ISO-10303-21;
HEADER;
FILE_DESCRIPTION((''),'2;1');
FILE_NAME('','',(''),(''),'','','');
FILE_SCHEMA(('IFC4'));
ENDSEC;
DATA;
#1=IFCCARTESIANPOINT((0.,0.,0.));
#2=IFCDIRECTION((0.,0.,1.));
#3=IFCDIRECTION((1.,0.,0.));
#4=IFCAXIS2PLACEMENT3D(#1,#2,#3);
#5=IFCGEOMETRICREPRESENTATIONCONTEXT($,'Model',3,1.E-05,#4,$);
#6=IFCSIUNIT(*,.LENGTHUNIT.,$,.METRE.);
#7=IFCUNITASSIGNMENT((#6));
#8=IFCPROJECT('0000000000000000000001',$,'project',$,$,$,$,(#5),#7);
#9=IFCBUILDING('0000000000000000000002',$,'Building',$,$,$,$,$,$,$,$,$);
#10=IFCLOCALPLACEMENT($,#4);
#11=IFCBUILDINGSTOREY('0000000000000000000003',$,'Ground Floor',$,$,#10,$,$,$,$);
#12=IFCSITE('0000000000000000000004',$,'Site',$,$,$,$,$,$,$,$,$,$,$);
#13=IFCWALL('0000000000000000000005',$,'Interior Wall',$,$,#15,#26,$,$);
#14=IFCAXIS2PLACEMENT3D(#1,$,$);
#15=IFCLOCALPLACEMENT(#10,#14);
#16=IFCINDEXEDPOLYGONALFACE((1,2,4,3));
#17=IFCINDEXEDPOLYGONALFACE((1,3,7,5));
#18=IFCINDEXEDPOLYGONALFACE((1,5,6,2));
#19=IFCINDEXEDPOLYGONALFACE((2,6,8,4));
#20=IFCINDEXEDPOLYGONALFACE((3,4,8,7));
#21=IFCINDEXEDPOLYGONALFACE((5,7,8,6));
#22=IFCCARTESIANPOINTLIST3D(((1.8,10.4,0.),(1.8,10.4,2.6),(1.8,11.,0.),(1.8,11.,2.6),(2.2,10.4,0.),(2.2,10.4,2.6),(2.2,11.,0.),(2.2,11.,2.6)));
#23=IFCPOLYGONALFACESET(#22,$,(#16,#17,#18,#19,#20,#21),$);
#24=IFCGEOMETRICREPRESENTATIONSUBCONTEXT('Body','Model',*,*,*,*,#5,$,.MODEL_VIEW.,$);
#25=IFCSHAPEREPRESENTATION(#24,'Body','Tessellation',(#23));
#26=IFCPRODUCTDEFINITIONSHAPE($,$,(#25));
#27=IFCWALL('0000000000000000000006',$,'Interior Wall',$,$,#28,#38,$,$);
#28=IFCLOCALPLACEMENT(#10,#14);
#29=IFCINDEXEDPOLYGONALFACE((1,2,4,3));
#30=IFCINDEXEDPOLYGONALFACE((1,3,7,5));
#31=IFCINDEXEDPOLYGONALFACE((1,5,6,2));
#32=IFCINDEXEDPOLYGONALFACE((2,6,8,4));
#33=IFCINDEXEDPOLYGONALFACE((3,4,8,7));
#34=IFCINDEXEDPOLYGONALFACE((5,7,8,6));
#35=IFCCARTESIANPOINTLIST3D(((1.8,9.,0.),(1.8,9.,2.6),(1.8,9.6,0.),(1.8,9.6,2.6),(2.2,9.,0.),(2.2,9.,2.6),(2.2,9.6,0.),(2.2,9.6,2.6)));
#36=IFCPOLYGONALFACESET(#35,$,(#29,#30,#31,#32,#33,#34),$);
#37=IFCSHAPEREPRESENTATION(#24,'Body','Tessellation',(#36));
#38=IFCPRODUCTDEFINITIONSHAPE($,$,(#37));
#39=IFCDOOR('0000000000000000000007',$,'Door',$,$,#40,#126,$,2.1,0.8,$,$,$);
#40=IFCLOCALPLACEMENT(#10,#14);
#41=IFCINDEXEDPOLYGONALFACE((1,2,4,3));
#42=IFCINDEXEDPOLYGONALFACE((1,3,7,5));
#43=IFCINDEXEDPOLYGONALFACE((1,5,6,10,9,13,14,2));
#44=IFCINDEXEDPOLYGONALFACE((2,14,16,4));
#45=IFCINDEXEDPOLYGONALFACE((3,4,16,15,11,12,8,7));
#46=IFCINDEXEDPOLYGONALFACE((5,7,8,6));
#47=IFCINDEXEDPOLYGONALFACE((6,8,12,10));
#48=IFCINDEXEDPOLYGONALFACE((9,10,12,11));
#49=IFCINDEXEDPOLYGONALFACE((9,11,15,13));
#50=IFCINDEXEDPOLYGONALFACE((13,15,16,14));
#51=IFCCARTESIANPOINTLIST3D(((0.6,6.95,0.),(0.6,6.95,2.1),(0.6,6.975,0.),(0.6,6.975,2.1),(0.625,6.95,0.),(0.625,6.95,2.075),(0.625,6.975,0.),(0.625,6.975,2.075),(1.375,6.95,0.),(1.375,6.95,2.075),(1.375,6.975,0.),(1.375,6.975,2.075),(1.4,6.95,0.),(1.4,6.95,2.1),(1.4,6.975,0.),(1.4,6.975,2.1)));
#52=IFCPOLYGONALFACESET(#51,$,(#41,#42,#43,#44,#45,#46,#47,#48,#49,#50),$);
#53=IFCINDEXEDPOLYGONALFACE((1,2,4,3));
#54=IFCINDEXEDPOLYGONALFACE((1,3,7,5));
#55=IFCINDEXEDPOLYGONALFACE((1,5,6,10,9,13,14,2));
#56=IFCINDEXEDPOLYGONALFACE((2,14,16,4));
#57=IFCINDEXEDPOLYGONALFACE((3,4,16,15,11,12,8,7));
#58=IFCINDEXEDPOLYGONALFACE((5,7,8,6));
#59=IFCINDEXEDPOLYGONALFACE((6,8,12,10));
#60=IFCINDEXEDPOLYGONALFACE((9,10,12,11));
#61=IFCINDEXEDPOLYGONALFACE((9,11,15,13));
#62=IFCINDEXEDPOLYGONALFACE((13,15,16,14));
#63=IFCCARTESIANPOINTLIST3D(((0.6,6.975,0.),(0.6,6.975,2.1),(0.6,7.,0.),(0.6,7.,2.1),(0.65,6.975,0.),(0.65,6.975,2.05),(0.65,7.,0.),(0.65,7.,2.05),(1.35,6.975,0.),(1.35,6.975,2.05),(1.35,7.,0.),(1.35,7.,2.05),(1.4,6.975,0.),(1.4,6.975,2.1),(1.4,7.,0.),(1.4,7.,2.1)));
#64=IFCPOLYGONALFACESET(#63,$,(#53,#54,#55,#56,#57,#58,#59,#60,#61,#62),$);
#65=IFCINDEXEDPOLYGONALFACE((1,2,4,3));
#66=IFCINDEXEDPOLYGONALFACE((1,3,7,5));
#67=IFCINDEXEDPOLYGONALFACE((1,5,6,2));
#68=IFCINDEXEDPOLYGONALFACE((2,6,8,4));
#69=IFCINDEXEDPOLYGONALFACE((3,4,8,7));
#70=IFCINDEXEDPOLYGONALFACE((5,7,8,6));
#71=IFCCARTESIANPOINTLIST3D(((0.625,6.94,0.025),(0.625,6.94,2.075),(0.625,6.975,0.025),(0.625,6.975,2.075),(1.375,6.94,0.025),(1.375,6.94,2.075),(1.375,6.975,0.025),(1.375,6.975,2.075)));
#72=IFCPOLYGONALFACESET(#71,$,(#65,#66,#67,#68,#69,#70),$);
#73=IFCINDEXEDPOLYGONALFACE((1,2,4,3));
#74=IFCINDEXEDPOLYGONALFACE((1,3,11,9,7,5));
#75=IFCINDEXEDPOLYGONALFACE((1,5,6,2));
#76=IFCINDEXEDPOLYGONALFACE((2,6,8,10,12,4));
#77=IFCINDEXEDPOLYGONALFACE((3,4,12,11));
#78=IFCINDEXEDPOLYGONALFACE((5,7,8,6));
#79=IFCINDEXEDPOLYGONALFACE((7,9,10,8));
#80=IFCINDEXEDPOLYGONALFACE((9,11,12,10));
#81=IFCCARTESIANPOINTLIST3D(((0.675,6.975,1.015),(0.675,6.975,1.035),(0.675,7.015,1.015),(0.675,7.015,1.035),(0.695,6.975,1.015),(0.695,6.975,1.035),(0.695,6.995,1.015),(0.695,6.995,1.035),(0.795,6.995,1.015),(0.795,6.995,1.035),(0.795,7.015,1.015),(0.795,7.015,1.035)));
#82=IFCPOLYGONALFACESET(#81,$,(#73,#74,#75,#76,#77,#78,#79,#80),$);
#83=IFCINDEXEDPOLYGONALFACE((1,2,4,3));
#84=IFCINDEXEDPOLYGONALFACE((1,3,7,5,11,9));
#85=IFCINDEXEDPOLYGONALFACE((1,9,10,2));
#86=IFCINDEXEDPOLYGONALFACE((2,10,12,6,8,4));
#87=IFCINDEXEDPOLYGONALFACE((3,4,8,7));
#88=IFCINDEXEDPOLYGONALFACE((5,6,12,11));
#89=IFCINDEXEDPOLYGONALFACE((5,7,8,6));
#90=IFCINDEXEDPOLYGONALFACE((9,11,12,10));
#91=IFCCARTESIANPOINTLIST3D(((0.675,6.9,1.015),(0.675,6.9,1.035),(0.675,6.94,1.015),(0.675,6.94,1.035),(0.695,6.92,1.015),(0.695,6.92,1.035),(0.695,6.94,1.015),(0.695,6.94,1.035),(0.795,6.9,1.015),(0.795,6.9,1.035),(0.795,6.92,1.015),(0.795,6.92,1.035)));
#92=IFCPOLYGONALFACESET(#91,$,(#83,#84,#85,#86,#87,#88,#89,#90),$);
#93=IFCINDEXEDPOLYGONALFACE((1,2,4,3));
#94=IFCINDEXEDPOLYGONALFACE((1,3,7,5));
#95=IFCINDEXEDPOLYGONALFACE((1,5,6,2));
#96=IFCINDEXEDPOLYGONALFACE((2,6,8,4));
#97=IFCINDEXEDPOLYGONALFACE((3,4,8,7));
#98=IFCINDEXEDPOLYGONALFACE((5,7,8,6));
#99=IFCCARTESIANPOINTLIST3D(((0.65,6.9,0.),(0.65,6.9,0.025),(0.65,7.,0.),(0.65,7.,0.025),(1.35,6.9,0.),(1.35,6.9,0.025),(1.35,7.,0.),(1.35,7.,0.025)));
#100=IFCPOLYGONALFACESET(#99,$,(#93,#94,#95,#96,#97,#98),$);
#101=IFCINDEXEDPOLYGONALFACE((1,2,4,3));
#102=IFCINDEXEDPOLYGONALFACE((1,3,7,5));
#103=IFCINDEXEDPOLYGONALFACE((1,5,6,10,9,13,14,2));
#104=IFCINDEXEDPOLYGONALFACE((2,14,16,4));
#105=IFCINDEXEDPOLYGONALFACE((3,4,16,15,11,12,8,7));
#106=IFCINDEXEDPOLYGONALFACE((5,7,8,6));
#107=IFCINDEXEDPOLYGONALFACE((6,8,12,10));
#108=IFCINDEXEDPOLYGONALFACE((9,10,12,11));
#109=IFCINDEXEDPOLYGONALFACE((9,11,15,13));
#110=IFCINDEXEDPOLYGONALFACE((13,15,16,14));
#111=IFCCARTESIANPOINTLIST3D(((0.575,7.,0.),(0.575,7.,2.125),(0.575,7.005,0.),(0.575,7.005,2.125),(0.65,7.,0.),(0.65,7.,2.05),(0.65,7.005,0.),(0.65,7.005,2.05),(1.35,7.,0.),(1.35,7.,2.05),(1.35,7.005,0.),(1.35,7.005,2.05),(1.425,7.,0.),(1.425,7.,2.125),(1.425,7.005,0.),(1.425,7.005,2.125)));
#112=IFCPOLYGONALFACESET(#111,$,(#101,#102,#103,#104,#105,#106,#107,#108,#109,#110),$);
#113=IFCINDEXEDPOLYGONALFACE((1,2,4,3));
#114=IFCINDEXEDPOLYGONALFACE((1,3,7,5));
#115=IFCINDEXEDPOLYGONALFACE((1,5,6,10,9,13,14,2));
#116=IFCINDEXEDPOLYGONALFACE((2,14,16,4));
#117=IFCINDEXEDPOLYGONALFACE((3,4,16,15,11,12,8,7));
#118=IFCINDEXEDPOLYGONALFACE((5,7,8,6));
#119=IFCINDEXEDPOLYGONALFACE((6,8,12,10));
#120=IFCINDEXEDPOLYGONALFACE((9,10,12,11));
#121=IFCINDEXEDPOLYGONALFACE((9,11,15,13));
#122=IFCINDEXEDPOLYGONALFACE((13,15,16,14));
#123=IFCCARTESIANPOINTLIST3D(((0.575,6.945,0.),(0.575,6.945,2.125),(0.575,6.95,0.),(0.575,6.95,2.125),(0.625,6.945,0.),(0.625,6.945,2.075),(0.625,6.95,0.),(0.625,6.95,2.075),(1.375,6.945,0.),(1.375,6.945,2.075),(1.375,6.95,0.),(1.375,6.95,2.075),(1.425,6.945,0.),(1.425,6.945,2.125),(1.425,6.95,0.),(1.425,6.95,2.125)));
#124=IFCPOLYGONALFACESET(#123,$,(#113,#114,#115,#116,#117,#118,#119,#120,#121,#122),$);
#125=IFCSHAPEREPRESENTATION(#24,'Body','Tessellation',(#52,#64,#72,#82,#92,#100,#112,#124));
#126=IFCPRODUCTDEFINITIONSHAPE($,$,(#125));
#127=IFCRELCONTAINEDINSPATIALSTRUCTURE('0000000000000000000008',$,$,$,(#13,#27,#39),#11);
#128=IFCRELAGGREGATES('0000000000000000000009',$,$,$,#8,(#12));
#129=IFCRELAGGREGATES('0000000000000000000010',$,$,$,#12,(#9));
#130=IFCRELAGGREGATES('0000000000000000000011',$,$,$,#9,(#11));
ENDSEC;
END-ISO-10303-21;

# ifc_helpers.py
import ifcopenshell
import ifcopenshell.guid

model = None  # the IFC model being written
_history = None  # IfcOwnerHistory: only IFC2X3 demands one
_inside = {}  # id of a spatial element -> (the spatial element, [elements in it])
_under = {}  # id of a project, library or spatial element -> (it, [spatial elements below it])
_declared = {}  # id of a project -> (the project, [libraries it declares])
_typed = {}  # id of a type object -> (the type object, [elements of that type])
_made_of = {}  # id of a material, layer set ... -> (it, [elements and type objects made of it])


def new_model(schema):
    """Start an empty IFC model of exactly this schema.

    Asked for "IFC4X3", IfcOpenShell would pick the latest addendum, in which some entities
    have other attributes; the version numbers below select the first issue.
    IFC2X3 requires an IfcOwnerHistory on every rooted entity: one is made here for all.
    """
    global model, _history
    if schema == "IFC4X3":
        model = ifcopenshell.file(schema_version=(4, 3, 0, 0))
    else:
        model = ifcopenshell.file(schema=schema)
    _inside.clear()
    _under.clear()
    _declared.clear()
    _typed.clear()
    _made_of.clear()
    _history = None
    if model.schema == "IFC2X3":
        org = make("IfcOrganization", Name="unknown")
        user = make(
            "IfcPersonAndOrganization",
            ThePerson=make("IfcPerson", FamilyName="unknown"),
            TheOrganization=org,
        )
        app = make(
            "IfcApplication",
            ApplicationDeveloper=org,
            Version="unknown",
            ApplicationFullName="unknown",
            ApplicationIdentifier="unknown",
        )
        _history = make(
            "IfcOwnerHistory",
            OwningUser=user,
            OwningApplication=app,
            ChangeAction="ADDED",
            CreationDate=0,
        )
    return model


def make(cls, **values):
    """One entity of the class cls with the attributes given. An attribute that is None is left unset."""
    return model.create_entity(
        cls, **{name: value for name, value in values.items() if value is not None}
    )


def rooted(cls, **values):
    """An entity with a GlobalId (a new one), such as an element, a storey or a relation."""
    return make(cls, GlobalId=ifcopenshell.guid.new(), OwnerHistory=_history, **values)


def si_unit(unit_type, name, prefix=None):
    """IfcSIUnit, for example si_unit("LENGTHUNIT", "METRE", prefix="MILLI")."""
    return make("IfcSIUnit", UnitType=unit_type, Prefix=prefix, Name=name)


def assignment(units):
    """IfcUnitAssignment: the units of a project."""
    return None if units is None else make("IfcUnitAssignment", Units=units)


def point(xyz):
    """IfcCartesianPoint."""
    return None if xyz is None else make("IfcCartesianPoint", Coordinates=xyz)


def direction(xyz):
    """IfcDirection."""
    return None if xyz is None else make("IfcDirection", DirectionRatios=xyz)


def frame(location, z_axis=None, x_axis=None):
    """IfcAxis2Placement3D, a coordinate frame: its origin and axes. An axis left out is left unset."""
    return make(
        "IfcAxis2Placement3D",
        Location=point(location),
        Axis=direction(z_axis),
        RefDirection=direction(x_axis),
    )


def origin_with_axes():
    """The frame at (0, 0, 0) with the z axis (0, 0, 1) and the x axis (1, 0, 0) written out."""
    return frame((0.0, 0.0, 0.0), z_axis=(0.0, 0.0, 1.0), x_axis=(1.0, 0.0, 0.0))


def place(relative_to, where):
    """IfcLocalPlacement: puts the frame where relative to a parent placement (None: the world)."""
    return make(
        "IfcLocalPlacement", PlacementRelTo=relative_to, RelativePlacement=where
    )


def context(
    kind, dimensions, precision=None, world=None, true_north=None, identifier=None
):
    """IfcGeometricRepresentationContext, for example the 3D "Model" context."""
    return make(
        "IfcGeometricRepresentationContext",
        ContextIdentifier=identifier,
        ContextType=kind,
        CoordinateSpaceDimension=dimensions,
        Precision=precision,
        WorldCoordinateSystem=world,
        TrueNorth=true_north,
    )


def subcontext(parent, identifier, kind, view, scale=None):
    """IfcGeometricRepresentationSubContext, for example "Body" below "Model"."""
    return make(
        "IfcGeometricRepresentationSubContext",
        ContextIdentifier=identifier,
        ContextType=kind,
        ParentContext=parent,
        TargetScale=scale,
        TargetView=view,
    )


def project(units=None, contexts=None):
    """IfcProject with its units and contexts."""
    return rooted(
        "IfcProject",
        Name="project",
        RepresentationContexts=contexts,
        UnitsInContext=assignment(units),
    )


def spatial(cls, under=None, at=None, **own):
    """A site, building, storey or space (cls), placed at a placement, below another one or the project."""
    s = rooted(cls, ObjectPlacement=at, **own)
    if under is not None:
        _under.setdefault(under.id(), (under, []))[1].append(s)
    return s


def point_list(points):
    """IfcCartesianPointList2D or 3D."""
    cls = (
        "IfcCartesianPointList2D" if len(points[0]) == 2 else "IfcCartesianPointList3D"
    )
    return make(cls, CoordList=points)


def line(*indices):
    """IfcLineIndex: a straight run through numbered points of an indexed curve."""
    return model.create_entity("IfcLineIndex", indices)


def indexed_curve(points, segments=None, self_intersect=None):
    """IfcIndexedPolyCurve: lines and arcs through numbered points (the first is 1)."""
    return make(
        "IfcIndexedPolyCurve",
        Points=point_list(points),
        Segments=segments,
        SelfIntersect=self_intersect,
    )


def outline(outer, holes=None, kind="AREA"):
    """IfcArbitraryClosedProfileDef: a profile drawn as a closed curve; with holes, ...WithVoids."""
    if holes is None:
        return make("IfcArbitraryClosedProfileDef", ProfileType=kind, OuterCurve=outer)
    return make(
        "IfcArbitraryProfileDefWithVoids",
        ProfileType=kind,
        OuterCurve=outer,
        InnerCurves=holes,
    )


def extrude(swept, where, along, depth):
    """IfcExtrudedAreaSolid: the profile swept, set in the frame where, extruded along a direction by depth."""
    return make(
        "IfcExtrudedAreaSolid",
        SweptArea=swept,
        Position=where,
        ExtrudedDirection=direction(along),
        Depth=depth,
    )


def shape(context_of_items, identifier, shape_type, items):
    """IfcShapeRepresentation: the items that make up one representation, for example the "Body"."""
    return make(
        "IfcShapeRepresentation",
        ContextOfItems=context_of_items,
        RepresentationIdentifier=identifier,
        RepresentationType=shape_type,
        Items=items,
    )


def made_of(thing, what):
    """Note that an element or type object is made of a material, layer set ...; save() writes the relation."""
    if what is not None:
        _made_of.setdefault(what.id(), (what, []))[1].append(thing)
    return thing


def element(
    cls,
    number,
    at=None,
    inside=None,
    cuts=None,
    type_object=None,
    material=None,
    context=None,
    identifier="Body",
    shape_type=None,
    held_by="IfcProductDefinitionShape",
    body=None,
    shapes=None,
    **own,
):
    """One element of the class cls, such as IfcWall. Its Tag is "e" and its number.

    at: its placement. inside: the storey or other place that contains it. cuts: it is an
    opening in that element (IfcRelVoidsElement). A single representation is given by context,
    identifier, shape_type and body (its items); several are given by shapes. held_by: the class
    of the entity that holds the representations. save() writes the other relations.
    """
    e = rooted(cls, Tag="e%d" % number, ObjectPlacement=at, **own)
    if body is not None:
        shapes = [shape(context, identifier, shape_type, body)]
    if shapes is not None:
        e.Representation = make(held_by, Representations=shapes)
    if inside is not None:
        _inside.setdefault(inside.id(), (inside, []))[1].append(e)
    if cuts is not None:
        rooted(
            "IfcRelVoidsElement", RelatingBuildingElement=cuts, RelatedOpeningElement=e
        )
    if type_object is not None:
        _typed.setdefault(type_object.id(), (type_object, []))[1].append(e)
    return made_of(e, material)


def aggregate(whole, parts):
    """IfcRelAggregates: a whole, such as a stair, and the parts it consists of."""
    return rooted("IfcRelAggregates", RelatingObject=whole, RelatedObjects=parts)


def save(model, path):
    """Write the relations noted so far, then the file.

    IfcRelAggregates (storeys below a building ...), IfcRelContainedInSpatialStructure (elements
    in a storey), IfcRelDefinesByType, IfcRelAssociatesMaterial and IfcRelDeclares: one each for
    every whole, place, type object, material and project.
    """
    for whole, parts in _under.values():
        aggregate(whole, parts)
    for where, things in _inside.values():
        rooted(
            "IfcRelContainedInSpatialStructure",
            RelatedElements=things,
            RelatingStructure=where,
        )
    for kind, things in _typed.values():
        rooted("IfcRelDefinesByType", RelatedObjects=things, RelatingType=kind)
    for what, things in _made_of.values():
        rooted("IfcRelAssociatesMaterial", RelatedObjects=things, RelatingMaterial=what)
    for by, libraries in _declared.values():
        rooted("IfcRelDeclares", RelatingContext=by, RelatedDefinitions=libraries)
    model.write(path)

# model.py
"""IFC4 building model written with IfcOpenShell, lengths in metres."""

from ifc_helpers import new_model, si_unit, frame, origin_with_axes, place, context, subcontext, project, spatial, line, indexed_curve, outline, extrude, element, save


model = new_model("IFC4")

# Units and contexts
model_context = context("Model", 3, precision=1e-05, world=origin_with_axes())
body_context = subcontext(model_context, "Body", "Model", "MODEL_VIEW")
ifc_project = project(units=[si_unit("LENGTHUNIT", "METRE")], contexts=[model_context])

# Site, building, storey
site = spatial("IfcSite", under=ifc_project, Name="Site")
building = spatial("IfcBuilding", under=site, Name="Building")
storey_placement = place(None, origin_with_axes())
storey = spatial("IfcBuildingStorey", under=building, at=storey_placement, Name="Ground Floor")

# Walls
for number, where, z_axis, x_axis, name in (
    (1, (2.0, 11.0, 0.0), (0.0, 0.0, 1.0), (0.0, -1.0, 0.0), "Interior Wall"),
    (2, (2.0, 9.6, 0.0), (0.0, 0.0, 1.0), (0.0, -1.0, 0.0), "Interior Wall"),
):
    element("IfcWall", number, at=place(storey_placement, frame(where, z_axis=z_axis, x_axis=x_axis)), inside=storey, Name=name, context=body_context, shape_type="SweptSolid", body=[
        extrude(outline(indexed_curve([(0.0, 0.0), (0.0, 0.4), (0.6, 0.4), (0.6, 0.0), (0.0, 0.0)], self_intersect=False)), frame((0.0, -0.2, 0.0), z_axis=(0.0, 0.0, 1.0), x_axis=(1.0, 0.0, 0.0)), (0.0, 0.0, 1.0), 2.6),
    ])

# Door
door_1_placement = place(storey_placement, frame((1.4, 7.0, 0.0), z_axis=(0.0, 0.0, 1.0), x_axis=(-1.0, 0.0, 0.0)))
element("IfcDoor", 3, at=door_1_placement, inside=storey, Name="Door", OverallHeight=2.1, OverallWidth=0.8, context=body_context, shape_type="SweptSolid", body=[
    extrude(outline(indexed_curve([(0.0, 0.0), (0.0, 2.1), (0.8, 2.1), (0.8, 0.0), (0.775, 0.0), (0.775, 2.075), (0.025, 2.075), (0.025, 0.0)], segments=[line(1, 2, 3, 4, 5, 6, 7, 8, 1)])), frame((0.0, 0.025, 0.0), z_axis=(0.0, -1.0, 0.0), x_axis=(1.0, 0.0, 0.0)), (0.0, 0.0, -1.0), 0.025),
    extrude(outline(indexed_curve([(0.0, 0.0), (0.0, 2.1), (0.8, 2.1), (0.8, 0.0), (0.75, 0.0), (0.75, 2.05), (0.05, 2.05), (0.05, 0.0)], segments=[line(1, 2, 3, 4, 5, 6, 7, 8, 1)])), frame((0.0, 0.0, 0.0), z_axis=(0.0, -1.0, 0.0), x_axis=(1.0, 0.0, 0.0)), (0.0, 0.0, -1.0), 0.025),
    extrude(outline(indexed_curve([(0.0, 0.0), (0.75, 0.0), (0.75, 0.035), (0.0, 0.035)], segments=[line(1, 2, 3, 4, 1)])), frame((0.025, 0.025, 0.025), z_axis=(0.0, 0.0, 1.0), x_axis=(1.0, 0.0, 0.0)), (0.0, 0.0, 1.0), 2.05),
    extrude(outline(indexed_curve([(0.0, 0.0), (0.0, -0.04), (-0.12, -0.04), (-0.12, -0.02), (-0.02, -0.02), (-0.02, 0.0)], segments=[line(1, 2, 3, 4, 5, 6, 1)])), frame((0.725, 0.025, 1.015), z_axis=(0.0, 0.0, 1.0), x_axis=(1.0, 0.0, 0.0)), (0.0, 0.0, 1.0), 0.02),
    extrude(outline(indexed_curve([(0.0, 0.0), (0.0, 0.04), (-0.12, 0.04), (-0.12, 0.02), (-0.02, 0.02), (-0.02, 0.0)], segments=[line(1, 2, 3, 4, 5, 6, 1)])), frame((0.725, 0.06, 1.015), z_axis=(0.0, 0.0, 1.0), x_axis=(1.0, 0.0, 0.0)), (0.0, 0.0, 1.0), 0.02),
    extrude(outline(indexed_curve([(0.0, 0.0), (0.7, 0.0), (0.7, 0.1), (0.0, 0.1)], segments=[line(1, 2, 3, 4, 1)])), frame((0.05, 0.0, 0.0), z_axis=(0.0, 0.0, 1.0), x_axis=(1.0, 0.0, 0.0)), (0.0, 0.0, 1.0), 0.025),
    extrude(outline(indexed_curve([(0.0, 0.0), (0.0, 2.125), (0.85, 2.125), (0.85, 0.0), (0.775, 0.0), (0.775, 2.05), (0.075, 2.05), (0.075, 0.0)], segments=[line(1, 2, 3, 4, 5, 6, 7, 8, 1)])), frame((-0.025, -0.005, 0.0), z_axis=(0.0, -1.0, 0.0), x_axis=(1.0, 0.0, 0.0)), (0.0, 0.0, -1.0), 0.005),
    extrude(outline(indexed_curve([(0.0, 0.0), (0.0, 2.125), (0.85, 2.125), (0.85, 0.0), (0.8, 0.0), (0.8, 2.075), (0.05, 2.075), (0.05, 0.0)], segments=[line(1, 2, 3, 4, 5, 6, 7, 8, 1)])), frame((-0.025, 0.05, 0.0), z_axis=(0.0, -1.0, 0.0), x_axis=(1.0, 0.0, 0.0)), (0.0, 0.0, -1.0), 0.005),
])

save(model, "model.ifc")
